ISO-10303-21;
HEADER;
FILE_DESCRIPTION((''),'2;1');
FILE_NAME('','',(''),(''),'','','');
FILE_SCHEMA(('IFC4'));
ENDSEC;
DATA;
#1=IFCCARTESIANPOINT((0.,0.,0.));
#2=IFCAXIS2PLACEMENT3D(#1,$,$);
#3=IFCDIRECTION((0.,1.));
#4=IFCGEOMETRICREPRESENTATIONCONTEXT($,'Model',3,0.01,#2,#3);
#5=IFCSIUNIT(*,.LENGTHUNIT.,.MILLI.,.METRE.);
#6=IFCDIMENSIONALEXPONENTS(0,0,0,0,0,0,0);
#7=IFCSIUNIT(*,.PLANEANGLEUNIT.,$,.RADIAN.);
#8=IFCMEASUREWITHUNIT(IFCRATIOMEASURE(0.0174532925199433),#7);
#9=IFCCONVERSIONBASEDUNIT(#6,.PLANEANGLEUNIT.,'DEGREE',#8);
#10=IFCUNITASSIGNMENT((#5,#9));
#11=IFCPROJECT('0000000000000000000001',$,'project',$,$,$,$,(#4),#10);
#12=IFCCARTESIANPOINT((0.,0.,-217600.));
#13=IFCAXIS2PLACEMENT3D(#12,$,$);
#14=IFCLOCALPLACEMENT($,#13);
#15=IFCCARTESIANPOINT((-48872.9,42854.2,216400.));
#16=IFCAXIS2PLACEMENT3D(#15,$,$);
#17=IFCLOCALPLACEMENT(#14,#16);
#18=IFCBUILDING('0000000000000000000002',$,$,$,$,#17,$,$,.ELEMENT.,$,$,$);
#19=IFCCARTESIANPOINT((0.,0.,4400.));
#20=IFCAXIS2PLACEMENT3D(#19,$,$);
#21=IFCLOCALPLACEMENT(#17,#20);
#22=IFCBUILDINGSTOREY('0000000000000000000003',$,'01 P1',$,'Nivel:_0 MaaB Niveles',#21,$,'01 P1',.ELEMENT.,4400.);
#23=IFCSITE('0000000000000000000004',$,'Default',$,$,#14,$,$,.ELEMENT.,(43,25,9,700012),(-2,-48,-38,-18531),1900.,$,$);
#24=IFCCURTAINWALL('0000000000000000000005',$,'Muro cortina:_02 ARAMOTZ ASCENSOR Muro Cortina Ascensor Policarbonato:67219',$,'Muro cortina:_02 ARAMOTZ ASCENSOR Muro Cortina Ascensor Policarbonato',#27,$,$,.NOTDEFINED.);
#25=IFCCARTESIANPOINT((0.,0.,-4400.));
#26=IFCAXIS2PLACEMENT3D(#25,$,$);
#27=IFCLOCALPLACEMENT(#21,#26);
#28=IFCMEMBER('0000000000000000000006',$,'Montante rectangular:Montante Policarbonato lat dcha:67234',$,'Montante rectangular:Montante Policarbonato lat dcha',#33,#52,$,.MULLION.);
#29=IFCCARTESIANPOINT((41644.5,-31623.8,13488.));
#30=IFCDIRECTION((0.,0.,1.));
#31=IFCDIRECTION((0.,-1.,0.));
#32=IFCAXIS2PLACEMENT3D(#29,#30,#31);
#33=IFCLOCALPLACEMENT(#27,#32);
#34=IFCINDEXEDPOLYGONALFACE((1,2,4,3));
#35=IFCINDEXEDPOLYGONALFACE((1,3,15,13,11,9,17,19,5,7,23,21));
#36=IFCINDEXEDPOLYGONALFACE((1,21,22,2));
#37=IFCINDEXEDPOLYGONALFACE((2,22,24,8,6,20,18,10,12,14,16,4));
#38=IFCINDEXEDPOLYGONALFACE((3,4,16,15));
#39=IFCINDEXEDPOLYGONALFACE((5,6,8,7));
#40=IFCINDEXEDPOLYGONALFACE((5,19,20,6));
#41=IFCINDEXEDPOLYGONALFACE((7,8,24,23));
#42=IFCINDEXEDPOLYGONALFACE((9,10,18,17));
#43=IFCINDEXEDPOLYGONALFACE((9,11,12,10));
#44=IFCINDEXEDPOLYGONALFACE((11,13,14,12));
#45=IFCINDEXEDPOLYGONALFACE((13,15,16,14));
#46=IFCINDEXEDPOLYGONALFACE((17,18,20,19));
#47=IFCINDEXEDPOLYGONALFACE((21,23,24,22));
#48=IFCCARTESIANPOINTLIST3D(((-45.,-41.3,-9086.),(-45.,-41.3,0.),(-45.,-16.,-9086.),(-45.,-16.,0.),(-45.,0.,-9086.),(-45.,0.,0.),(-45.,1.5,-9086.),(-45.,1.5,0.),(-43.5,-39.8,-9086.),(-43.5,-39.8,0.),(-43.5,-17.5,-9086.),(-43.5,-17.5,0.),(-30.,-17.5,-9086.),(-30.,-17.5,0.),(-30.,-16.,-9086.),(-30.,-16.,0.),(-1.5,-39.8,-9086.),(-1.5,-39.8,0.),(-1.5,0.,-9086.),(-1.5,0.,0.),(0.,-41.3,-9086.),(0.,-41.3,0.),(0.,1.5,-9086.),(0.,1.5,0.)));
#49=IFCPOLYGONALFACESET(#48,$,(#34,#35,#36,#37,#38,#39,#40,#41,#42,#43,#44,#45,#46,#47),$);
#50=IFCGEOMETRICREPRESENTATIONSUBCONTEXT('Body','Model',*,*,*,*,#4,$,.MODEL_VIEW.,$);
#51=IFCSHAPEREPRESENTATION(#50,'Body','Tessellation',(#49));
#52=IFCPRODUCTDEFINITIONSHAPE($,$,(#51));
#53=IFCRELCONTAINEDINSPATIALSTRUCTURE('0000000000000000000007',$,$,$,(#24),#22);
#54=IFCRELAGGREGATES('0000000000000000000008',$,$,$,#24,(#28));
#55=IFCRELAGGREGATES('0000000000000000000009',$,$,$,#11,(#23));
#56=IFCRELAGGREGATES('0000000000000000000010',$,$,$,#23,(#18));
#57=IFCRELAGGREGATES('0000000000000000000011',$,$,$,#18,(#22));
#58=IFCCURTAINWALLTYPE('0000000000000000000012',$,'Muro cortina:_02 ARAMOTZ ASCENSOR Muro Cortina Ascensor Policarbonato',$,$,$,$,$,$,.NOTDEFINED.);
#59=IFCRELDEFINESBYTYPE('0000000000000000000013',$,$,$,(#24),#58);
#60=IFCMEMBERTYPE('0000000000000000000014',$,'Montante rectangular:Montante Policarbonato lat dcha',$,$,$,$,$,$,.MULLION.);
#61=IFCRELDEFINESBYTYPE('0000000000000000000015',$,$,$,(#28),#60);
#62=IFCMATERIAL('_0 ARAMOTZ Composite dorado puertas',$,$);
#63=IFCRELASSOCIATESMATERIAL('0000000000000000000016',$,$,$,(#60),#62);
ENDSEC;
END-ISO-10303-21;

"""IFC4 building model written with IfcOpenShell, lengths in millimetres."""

from ifc_helpers import new_model, entity, si_unit, converted_unit, direction, frame, origin, place, context, subcontext, project, spatial, indexed_curve, outline, extrude, source, transform, mapped, material, type_object, type_shapes, element, aggregate, save


model = new_model("IFC4")

# Units and contexts
model_context = context("Model", 3, precision=0.01, world=origin(), true_north=direction((0.0, 1.0)))
body_context = subcontext(model_context, "Body", "Model", "MODEL_VIEW")
ifc_project = project(units=[si_unit("LENGTHUNIT", "METRE", prefix="MILLI"), converted_unit("PLANEANGLEUNIT", "DEGREE", entity("IfcRatioMeasure", 0.0174532925199433), si_unit("PLANEANGLEUNIT", "RADIAN"), dimensions=[0, 0, 0, 0, 0, 0, 0])], contexts=[model_context])

# Site, building, storey
site_placement = place(None, frame((0.0, 0.0, -217600.0)))
site = spatial("IfcSite", under=ifc_project, at=site_placement, Name="Default", CompositionType="ELEMENT", RefLatitude=(43, 25, 9, 700012), RefLongitude=(-2, -48, -38, -18531), RefElevation=1900.0)
building_placement = place(site_placement, frame((-48872.9, 42854.2, 216400.0)))
building = spatial("IfcBuilding", under=site, at=building_placement, CompositionType="ELEMENT")
storey_placement = place(building_placement, frame((0.0, 0.0, 4400.0)))
storey = spatial("IfcBuildingStorey", under=building, at=storey_placement, Name="01 P1", ObjectType="Nivel:_0 MaaB Niveles", LongName="01 P1", CompositionType="ELEMENT", Elevation=4400.0)

# Curtain wall, member
curtain_wall_type_1 = type_object("IfcCurtainWallType", Name="Muro cortina:_02 ARAMOTZ ASCENSOR Muro Cortina Ascensor Policarbonato", PredefinedType="NOTDEFINED")
curtain_wall_1_placement = place(storey_placement, frame((0.0, 0.0, -4400.0)))
curtain_wall_1 = element("IfcCurtainWall", 1, at=curtain_wall_1_placement, inside=storey, type_object=curtain_wall_type_1, Name="Muro cortina:_02 ARAMOTZ ASCENSOR Muro Cortina Ascensor Policarbonato:67219", ObjectType="Muro cortina:_02 ARAMOTZ ASCENSOR Muro Cortina Ascensor Policarbonato", PredefinedType="NOTDEFINED")
ifc_material_1 = material(Name="_0 ARAMOTZ Composite dorado puertas")
member_type = type_object("IfcMemberType", Name="Montante rectangular:Montante Policarbonato lat dcha", PredefinedType="MULLION", material=ifc_material_1)
shared_shape_1 = source(origin(), body_context, "Body", "SweptSolid", [
    extrude(outline(indexed_curve([(-2.9, -17.5), (22.5, -17.5), (22.5, 27.5), (-20.4, 27.5), (-20.4, -17.5), (-18.9, -17.5), (-18.9, 26.0), (21.0, 26.0), (21.0, -16.0), (-1.4, -16.0), (-1.4, -2.5), (-2.9, -2.5), (-2.9, -17.5)], self_intersect=False)), frame((-27.5, -18.9, -9086.0), z_axis=(0.0, 0.0, 1.0), x_axis=(0.0, -1.0, 0.0)), (0.0, 0.0, 1.0), 9086.0),
])
type_shapes(member_type, [shared_shape_1])
member_placement = place(curtain_wall_1_placement, frame((41644.5, -31623.8, 13488.0), z_axis=(0.0, 0.0, 1.0), x_axis=(0.0, -1.0, 0.0)))
member = element("IfcMember", 2, at=member_placement, type_object=member_type, Name="Montante rectangular:Montante Policarbonato lat dcha:67234", ObjectType="Montante rectangular:Montante Policarbonato lat dcha", PredefinedType="MULLION", context=body_context, shape_type="MappedRepresentation", body=[
    mapped(shared_shape_1, transform((0.0, 0.0, 0.0), scale=1.0)),
])

aggregate(curtain_wall_1, [member])

save(model, "model.ifc")
